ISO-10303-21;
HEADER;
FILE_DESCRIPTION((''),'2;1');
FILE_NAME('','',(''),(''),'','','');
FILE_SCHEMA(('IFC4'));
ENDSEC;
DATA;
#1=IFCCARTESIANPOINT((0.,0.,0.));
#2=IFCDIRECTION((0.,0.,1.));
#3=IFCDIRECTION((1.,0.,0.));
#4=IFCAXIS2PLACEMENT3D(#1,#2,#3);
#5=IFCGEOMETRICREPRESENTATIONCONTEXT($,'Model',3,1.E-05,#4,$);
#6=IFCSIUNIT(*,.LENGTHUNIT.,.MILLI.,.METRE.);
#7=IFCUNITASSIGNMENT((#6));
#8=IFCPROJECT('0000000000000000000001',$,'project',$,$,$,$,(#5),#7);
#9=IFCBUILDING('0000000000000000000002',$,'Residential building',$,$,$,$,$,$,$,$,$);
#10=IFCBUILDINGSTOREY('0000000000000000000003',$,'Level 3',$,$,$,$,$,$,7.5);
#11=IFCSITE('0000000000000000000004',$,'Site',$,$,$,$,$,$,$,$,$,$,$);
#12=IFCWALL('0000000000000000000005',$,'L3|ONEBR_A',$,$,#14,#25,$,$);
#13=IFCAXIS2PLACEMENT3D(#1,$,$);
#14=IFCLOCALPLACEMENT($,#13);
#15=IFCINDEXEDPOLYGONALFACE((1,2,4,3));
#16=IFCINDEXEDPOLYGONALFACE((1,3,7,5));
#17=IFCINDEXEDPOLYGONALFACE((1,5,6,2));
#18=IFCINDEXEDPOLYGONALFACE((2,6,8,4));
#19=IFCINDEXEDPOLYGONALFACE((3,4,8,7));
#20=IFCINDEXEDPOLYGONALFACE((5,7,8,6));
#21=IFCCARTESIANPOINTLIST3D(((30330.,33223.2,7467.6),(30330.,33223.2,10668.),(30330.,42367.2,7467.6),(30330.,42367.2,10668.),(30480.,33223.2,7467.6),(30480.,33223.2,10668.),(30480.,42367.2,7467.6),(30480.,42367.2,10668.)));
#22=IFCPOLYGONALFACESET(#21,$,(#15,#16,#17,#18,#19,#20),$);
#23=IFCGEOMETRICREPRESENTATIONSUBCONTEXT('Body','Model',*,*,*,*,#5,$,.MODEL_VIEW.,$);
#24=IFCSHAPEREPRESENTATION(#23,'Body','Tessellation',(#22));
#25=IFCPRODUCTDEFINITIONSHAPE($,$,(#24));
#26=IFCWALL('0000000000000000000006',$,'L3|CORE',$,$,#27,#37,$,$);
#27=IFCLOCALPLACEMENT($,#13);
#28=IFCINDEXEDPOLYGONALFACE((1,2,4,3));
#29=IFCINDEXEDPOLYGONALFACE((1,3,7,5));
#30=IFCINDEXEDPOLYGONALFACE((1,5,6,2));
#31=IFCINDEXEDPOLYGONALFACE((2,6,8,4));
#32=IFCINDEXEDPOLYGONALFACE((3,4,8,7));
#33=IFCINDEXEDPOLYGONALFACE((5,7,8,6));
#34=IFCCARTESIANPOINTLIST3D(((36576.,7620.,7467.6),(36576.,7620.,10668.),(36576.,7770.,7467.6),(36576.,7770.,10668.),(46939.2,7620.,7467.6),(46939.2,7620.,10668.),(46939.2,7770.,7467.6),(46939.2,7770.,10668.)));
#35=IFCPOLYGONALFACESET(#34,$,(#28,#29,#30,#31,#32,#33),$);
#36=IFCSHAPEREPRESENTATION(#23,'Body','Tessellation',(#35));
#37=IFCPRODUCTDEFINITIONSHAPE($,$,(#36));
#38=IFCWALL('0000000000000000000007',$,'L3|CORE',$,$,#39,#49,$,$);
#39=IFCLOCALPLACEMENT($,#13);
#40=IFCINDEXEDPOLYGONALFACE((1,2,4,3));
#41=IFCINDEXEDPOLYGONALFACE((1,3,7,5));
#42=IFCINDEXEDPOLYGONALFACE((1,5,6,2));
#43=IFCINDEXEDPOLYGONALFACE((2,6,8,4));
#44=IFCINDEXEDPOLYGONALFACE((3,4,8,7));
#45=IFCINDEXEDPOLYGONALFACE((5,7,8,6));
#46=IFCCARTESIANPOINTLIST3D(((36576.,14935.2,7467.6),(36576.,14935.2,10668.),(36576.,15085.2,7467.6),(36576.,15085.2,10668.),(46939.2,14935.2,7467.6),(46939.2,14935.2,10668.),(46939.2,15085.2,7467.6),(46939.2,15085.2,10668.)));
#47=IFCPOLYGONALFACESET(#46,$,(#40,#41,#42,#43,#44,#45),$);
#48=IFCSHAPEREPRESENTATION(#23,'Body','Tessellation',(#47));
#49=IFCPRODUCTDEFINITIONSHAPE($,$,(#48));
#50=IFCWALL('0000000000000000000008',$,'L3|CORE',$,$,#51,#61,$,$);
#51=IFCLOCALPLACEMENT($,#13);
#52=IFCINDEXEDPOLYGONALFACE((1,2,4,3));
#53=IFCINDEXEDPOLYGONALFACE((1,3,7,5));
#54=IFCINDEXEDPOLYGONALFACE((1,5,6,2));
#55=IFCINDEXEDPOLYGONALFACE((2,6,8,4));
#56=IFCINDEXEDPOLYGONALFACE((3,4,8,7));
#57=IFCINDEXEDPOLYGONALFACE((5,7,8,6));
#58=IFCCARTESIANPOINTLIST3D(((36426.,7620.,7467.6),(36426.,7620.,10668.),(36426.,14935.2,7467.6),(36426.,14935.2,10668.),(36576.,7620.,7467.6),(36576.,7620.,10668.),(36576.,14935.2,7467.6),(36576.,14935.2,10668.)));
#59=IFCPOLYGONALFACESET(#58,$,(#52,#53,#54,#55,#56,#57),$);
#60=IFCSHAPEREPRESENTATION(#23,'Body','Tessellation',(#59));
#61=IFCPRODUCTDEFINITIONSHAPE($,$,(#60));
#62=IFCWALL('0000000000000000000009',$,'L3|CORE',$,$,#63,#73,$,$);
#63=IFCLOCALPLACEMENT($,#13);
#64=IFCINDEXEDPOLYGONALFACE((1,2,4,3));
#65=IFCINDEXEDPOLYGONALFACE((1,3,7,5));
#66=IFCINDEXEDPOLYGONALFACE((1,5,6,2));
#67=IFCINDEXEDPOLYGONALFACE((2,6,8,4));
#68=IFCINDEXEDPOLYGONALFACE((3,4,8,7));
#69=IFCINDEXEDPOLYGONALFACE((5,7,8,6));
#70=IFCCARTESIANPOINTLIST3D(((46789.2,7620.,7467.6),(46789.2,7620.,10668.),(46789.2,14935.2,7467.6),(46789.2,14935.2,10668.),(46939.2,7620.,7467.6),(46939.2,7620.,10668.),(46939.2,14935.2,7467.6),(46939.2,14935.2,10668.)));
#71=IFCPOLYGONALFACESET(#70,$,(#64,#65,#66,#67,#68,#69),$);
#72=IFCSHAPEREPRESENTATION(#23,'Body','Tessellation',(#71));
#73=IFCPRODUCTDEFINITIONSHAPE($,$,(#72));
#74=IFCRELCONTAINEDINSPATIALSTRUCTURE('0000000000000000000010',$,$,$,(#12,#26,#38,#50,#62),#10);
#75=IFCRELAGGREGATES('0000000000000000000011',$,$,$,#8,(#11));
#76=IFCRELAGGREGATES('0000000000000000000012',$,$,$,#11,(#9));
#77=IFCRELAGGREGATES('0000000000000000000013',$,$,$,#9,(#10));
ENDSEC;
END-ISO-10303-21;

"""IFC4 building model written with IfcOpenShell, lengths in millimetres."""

from ifc_helpers import new_model, si_unit, frame, origin_with_axes, place, context, subcontext, project, spatial, indexed_curve, outline, extrude, element, save


model = new_model("IFC4")

# Units and contexts
model_context = context("Model", 3, precision=1e-05, world=origin_with_axes())
body_context = subcontext(model_context, "Body", "Model", "MODEL_VIEW")
ifc_project = project(units=[si_unit("LENGTHUNIT", "METRE", prefix="MILLI")], contexts=[model_context])

# Site, building, storey
site = spatial("IfcSite", under=ifc_project, Name="Site")
building = spatial("IfcBuilding", under=site, Name="Residential building")
storey = spatial("IfcBuildingStorey", under=building, Name="Level 3", Elevation=7.5)

# Walls
wall_1_placement = place(None, frame((30480.0, 33223.2, 7467.6), z_axis=(0.0, 0.0, 1.0), x_axis=(0.0, 1.0, 0.0)))
element("IfcWall", 1, at=wall_1_placement, inside=storey, Name="L3|ONEBR_A", context=body_context, shape_type="SweptSolid", body=[
    extrude(outline(indexed_curve([(0.0, 0.0), (0.0, 150.0), (9144.0, 150.0), (9144.0, 0.0), (0.0, 0.0)], self_intersect=False)), origin_with_axes(), (0.0, 0.0, 1.0), 3200.4),
])
for number, where, z_axis, x_axis, name in (
    (2, (36576.0, 7620.0, 7467.6), (0.0, 0.0, 1.0), (1.0, 0.0, 0.0), "L3|CORE"),
    (3, (36576.0, 14935.2, 7467.6), (0.0, 0.0, 1.0), (1.0, 0.0, 0.0), "L3|CORE"),
):
    element("IfcWall", number, at=place(None, frame(where, z_axis=z_axis, x_axis=x_axis)), inside=storey, Name=name, context=body_context, shape_type="SweptSolid", body=[
        extrude(outline(indexed_curve([(0.0, 0.0), (0.0, 150.0), (10363.2, 150.0), (10363.2, 0.0), (0.0, 0.0)], self_intersect=False)), origin_with_axes(), (0.0, 0.0, 1.0), 3200.4),
    ])
for number, where, z_axis, x_axis, name in (
    (4, (36576.0, 7620.0, 7467.6), (0.0, 0.0, 1.0), (0.0, 1.0, 0.0), "L3|CORE"),
    (5, (46939.2, 7620.0, 7467.6), (0.0, 0.0, 1.0), (0.0, 1.0, 0.0), "L3|CORE"),
):
    element("IfcWall", number, at=place(None, frame(where, z_axis=z_axis, x_axis=x_axis)), inside=storey, Name=name, context=body_context, shape_type="SweptSolid", body=[
        extrude(outline(indexed_curve([(0.0, 0.0), (0.0, 150.0), (7315.2, 150.0), (7315.2, 0.0), (0.0, 0.0)], self_intersect=False)), origin_with_axes(), (0.0, 0.0, 1.0), 3200.4),
    ])

save(model, "model.ifc")
